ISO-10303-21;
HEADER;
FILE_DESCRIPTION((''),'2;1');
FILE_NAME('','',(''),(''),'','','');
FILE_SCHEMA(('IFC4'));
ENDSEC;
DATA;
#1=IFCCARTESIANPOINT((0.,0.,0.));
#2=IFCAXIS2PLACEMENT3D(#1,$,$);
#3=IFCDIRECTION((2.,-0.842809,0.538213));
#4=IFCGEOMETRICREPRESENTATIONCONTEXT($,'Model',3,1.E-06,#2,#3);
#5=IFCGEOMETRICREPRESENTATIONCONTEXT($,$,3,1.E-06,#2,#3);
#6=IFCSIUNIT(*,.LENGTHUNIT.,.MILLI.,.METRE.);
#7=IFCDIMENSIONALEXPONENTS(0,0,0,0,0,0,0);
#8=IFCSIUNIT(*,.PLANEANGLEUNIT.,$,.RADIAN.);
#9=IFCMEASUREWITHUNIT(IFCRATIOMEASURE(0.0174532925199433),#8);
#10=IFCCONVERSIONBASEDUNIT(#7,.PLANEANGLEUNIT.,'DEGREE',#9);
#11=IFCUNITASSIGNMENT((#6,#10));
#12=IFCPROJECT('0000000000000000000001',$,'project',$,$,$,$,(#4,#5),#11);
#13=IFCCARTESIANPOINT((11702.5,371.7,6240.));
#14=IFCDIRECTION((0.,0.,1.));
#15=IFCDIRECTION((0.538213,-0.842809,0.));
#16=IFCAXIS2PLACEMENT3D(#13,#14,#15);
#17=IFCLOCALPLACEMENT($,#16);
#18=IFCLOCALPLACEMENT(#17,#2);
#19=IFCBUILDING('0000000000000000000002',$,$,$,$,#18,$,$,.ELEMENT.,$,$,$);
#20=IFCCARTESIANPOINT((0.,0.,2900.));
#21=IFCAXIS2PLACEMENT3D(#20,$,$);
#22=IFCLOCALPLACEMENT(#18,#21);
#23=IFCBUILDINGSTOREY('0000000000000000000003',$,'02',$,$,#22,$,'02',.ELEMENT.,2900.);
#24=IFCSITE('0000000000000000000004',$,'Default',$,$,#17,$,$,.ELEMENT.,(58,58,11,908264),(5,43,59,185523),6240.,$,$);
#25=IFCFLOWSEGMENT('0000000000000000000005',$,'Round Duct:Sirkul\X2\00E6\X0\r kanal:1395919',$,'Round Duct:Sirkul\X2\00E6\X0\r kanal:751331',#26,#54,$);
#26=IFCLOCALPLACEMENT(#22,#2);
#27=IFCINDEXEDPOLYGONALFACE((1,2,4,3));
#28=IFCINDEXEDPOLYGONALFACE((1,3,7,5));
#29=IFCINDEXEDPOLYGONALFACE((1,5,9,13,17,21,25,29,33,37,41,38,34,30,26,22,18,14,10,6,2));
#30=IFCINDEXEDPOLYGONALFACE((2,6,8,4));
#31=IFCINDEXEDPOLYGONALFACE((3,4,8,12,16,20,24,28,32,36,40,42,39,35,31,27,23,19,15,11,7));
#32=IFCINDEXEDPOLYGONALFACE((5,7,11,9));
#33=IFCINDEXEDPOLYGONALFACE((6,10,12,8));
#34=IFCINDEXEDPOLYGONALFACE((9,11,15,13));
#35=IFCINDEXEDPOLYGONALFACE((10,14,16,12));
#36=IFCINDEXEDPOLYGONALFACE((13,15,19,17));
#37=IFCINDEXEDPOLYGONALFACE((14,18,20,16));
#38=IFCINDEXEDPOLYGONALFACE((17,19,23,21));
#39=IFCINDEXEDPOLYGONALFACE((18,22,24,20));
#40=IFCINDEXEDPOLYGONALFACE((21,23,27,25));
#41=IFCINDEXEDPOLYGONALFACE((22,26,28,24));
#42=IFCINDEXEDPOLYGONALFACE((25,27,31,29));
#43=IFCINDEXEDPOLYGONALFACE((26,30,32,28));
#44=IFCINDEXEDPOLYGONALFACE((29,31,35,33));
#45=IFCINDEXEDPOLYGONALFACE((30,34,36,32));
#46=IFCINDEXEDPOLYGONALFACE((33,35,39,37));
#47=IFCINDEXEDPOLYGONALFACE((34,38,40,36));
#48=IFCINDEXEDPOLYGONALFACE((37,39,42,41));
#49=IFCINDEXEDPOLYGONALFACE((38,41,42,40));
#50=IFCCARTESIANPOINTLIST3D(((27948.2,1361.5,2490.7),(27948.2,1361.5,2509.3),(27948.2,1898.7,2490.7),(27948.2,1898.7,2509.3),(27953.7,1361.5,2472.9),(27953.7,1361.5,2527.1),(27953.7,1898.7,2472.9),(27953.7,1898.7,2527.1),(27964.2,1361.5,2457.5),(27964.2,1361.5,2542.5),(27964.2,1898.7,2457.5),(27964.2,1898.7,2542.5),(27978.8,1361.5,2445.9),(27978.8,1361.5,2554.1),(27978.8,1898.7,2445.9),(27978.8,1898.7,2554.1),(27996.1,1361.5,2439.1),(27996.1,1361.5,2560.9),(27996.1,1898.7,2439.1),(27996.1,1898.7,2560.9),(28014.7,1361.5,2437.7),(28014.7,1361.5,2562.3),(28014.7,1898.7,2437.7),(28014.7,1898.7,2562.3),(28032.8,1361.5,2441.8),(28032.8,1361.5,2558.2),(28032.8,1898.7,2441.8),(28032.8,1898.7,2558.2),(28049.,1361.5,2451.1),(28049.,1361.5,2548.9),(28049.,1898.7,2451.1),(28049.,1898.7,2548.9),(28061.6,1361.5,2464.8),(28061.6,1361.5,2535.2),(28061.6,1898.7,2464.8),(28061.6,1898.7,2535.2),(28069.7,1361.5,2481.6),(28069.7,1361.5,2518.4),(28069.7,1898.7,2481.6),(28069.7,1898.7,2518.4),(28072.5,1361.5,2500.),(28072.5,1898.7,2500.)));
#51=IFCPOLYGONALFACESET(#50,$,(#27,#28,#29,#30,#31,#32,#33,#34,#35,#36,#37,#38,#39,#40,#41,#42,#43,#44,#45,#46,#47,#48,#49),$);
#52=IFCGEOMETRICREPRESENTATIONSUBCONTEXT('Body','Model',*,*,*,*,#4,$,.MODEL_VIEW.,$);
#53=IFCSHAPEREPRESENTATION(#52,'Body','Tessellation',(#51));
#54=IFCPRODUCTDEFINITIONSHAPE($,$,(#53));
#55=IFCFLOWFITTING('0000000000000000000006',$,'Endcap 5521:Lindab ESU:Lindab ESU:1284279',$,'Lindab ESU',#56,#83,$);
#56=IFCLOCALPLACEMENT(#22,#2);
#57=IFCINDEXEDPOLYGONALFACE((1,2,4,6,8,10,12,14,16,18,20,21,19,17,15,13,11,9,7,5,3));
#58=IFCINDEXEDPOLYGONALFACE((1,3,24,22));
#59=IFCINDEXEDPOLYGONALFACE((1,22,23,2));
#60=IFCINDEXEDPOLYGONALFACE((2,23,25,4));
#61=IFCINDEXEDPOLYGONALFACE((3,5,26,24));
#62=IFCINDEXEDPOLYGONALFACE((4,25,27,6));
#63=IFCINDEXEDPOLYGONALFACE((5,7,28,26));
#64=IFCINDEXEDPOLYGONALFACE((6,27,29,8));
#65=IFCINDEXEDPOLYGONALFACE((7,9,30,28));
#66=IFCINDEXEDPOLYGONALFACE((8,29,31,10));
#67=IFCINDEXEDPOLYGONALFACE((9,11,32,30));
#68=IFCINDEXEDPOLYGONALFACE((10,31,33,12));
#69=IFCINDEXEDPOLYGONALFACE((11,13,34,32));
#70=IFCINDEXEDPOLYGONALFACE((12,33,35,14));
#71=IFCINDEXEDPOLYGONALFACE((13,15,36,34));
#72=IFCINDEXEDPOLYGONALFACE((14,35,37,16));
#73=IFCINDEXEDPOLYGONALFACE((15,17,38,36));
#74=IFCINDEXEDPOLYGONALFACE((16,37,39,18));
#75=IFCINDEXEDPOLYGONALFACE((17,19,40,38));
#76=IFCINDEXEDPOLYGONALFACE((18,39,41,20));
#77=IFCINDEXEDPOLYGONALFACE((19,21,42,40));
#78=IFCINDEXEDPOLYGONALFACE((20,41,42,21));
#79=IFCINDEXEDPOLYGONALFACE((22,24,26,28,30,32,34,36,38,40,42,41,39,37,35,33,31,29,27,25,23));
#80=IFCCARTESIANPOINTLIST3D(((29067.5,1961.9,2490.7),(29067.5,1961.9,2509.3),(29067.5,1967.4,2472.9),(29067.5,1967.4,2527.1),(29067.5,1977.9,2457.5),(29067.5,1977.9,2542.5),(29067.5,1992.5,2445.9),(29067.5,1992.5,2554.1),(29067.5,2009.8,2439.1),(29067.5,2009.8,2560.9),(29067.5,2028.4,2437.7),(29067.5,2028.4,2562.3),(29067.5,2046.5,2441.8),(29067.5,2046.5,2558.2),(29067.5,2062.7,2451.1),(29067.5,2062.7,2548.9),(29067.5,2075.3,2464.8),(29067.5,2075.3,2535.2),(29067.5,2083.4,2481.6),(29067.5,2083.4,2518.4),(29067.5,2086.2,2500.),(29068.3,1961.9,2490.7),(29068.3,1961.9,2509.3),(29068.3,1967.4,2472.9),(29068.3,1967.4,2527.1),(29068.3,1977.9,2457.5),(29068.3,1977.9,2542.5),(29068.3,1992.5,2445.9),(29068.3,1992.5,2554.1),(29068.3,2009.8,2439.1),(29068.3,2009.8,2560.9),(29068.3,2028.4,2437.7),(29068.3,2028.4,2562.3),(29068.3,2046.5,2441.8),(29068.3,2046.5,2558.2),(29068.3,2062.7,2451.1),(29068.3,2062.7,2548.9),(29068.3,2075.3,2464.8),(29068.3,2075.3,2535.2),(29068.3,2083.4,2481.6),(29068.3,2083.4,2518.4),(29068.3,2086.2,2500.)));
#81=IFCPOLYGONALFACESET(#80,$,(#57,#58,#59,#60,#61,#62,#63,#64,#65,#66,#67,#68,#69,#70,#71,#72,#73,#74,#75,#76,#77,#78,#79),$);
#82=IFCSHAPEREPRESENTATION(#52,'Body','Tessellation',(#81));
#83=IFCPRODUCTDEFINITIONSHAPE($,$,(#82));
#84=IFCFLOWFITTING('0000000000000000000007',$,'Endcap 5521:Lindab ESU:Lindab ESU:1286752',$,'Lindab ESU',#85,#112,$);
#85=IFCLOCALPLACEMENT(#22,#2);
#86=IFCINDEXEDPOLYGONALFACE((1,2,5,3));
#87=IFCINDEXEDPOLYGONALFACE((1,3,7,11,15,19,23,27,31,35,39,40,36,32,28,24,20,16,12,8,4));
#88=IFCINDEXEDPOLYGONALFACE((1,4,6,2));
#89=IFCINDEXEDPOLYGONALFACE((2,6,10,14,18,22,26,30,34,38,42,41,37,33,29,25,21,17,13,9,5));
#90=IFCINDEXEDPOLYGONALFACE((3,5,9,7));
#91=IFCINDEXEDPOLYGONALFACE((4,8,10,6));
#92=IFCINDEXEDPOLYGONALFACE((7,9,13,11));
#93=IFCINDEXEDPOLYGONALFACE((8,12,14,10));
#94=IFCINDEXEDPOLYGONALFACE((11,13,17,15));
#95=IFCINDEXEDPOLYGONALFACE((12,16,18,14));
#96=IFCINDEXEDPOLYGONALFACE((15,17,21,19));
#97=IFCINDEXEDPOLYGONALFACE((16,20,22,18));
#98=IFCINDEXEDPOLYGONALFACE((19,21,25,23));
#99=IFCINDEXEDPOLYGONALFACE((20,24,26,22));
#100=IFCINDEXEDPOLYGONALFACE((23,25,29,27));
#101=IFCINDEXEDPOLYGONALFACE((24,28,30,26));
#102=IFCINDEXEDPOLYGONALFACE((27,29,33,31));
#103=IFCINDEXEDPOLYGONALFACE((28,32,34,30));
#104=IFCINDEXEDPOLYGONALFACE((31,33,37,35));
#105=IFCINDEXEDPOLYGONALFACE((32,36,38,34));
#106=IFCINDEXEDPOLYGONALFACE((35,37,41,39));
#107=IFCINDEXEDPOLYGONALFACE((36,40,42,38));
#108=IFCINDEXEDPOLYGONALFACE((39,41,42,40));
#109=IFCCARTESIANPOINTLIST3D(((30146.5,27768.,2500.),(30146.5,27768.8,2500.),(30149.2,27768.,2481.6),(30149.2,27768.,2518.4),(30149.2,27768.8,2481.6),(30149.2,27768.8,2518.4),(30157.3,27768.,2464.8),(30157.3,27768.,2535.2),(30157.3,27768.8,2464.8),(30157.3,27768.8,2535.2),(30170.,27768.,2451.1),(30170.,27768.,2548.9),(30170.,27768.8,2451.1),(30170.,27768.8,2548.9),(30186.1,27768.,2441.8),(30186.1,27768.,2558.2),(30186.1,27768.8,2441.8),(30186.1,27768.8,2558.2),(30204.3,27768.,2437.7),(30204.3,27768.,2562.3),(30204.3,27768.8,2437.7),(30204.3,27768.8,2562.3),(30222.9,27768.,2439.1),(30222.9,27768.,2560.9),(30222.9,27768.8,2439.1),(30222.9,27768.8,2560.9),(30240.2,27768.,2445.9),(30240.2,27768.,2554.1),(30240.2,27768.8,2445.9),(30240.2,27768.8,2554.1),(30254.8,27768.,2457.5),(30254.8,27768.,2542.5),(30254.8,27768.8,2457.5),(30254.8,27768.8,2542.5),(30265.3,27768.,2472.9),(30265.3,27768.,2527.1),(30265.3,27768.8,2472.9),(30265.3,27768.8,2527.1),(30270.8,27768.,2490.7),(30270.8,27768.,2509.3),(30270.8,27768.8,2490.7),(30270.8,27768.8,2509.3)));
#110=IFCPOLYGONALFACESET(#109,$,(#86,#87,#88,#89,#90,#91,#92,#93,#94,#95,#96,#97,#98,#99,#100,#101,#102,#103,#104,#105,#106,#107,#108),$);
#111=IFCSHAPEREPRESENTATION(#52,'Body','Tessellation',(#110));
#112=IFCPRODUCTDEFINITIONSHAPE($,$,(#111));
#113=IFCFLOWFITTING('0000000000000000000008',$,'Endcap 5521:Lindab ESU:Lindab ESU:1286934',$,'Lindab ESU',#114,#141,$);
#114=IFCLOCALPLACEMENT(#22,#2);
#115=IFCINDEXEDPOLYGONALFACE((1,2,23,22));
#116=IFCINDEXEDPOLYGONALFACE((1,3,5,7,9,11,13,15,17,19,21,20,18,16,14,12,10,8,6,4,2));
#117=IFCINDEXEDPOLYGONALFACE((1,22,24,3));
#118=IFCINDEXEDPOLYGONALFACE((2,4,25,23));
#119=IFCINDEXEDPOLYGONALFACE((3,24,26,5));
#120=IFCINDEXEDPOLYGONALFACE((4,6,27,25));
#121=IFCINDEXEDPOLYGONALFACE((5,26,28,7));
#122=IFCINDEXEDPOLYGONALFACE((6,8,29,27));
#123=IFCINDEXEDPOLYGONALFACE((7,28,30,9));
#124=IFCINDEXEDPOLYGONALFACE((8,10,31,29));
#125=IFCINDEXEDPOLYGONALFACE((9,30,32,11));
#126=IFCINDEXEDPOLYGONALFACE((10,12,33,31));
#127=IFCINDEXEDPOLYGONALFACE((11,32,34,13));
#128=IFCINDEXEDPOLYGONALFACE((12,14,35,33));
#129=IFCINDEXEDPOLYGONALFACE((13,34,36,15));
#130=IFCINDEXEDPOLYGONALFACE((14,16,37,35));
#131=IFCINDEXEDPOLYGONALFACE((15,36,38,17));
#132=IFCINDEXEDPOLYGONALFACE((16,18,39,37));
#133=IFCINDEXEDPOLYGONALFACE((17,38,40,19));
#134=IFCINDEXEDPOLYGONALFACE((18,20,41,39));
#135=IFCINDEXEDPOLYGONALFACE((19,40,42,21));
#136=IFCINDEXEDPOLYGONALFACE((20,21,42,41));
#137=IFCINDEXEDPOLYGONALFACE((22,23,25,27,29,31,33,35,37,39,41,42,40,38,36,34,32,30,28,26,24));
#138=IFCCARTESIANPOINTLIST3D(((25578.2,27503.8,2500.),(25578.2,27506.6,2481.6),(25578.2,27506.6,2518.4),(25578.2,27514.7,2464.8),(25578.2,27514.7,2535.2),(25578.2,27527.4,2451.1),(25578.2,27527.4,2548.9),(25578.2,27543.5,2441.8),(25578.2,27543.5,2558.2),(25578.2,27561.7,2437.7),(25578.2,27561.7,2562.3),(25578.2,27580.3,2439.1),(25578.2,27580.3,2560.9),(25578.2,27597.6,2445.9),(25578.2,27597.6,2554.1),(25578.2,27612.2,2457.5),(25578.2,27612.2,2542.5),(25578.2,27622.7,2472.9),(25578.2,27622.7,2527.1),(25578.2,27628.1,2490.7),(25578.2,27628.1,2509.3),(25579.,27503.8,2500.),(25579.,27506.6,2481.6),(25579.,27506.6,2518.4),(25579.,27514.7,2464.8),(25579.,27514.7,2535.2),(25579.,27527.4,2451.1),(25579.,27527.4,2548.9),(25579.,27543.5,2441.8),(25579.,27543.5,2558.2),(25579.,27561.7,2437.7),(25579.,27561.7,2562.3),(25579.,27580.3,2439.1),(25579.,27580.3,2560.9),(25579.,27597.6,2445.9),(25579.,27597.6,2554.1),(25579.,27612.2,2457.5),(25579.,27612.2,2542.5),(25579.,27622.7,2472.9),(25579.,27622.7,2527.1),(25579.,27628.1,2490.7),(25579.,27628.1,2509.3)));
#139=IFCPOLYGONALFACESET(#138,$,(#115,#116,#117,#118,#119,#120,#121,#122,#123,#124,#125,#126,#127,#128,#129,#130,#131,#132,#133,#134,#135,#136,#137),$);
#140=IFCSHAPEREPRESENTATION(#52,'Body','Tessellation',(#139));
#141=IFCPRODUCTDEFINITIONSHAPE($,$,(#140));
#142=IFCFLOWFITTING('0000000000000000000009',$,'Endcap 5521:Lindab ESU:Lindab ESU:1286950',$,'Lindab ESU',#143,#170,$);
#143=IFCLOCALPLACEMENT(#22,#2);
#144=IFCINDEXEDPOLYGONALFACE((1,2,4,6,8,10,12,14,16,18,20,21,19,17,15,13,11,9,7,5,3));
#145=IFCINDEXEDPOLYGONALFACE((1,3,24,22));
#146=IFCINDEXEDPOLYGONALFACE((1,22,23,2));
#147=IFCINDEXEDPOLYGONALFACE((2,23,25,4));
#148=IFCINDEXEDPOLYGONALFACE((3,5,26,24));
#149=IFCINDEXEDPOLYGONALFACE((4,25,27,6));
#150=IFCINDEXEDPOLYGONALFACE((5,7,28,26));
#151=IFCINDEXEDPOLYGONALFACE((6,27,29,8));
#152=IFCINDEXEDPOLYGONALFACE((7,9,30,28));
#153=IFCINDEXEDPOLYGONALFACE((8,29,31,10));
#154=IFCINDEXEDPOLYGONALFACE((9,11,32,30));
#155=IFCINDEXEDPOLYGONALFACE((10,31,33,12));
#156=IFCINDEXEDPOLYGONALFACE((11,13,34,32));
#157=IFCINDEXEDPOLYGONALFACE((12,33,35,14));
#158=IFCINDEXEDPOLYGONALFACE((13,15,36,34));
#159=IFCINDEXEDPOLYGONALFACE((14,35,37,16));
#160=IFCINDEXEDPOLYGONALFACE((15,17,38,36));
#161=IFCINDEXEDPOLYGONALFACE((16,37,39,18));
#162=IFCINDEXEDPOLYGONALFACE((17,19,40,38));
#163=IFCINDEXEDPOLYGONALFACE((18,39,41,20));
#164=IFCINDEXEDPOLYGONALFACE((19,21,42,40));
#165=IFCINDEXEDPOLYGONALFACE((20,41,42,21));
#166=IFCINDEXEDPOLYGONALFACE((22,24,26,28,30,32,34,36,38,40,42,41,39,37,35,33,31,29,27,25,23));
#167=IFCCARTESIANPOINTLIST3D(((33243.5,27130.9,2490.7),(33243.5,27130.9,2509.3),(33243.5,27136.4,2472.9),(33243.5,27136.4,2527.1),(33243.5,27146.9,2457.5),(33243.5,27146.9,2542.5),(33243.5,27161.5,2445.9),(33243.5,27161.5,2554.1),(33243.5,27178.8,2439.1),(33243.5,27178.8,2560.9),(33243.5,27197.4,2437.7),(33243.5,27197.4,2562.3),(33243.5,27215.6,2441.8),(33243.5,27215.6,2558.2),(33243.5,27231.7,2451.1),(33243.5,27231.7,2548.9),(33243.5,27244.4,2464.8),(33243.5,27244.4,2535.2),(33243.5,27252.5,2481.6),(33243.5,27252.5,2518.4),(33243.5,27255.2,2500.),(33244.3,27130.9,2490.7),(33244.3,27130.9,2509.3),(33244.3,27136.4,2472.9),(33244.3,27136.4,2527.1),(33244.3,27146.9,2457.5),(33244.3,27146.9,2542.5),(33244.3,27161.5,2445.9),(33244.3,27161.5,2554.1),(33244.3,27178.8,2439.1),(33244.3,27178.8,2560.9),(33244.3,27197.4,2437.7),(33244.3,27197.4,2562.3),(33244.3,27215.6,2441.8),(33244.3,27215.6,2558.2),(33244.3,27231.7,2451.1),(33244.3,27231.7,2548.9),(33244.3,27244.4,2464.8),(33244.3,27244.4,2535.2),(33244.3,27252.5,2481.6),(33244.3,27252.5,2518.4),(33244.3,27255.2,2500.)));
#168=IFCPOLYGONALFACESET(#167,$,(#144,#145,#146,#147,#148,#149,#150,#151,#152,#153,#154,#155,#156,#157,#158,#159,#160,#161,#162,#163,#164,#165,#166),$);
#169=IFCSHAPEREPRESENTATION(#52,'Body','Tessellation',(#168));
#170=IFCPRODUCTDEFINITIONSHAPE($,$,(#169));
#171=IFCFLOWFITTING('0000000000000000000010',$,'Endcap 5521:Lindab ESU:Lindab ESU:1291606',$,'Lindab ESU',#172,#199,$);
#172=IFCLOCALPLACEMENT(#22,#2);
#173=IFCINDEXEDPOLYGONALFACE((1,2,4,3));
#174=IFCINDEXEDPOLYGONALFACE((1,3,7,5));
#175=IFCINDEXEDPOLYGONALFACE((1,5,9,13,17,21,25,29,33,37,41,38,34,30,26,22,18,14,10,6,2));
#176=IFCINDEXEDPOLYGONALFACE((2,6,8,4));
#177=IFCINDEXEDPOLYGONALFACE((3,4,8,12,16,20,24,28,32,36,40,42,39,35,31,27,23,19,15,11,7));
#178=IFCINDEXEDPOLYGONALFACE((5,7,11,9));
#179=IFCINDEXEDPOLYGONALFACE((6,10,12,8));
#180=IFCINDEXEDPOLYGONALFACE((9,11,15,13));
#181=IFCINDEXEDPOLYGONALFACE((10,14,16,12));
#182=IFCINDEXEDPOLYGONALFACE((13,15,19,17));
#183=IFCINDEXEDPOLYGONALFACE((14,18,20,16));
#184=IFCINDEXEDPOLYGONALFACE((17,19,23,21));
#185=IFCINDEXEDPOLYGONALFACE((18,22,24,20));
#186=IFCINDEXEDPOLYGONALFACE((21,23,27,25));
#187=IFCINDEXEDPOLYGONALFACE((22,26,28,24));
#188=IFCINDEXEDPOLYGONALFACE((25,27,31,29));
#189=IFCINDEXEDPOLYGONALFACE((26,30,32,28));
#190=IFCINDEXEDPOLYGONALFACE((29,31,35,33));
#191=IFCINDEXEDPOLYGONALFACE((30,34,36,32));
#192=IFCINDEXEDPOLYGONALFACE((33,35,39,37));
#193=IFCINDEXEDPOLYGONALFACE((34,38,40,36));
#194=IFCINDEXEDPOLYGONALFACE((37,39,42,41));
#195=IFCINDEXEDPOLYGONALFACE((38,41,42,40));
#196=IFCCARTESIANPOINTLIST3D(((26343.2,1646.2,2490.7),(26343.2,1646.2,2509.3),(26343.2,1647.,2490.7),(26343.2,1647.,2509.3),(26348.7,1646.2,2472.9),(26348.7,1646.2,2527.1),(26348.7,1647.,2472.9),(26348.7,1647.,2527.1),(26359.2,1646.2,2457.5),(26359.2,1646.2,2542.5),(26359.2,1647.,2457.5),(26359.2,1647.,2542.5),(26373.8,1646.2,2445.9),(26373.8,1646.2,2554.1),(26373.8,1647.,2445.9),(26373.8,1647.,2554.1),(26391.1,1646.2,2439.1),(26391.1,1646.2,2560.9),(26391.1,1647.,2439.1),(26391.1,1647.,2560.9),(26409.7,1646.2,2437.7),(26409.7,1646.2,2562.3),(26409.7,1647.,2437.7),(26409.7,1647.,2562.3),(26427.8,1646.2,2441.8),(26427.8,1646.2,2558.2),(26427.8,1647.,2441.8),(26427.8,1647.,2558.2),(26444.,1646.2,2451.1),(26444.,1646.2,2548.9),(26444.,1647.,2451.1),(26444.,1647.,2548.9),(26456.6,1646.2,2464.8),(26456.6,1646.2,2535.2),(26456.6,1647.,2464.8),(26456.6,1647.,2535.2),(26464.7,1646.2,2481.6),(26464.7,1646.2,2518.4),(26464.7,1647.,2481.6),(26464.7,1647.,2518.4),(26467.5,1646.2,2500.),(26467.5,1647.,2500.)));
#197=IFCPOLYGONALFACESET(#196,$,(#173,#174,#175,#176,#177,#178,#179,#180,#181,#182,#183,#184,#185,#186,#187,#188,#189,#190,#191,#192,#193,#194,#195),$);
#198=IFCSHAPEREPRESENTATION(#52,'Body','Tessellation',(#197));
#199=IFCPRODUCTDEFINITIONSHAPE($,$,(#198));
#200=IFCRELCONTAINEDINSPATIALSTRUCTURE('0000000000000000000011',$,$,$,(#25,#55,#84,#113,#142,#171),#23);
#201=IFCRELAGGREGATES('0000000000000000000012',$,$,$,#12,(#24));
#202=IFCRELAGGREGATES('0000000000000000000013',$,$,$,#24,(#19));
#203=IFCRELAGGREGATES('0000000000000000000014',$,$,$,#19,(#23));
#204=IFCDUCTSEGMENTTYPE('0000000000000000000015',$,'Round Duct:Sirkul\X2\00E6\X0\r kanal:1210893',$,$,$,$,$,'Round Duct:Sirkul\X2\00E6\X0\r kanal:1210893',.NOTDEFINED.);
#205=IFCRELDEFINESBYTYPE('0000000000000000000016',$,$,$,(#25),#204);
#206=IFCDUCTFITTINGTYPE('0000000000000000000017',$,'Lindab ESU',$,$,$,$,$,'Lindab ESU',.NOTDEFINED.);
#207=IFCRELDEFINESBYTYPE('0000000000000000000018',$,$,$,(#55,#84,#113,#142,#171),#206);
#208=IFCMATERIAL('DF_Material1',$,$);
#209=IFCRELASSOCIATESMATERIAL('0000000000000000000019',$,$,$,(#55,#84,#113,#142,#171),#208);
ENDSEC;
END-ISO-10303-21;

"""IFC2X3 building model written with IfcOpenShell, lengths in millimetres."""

from ifc_helpers import new_model, entity, si_unit, converted_unit, direction, frame, frame_2d, origin, origin_2d_with_axis, place, context, subcontext, project, spatial, circle, extrude, source, transform, mapped, material, type_object, type_shapes, element, save


model = new_model("IFC2X3")

# Units and contexts
model_context = context("Model", 3, precision=1e-06, world=origin(), true_north=direction((2.0, -0.842809, 0.538213)))
context_of_model = context(None, 3, precision=1e-06, world=origin(), true_north=direction((2.0, -0.842809, 0.538213)))
body_context = subcontext(model_context, "Body", "Model", "MODEL_VIEW")
ifc_project = project(units=[si_unit("LENGTHUNIT", "METRE", prefix="MILLI"), converted_unit("PLANEANGLEUNIT", "DEGREE", entity("IfcRatioMeasure", 0.0174532925199433), si_unit("PLANEANGLEUNIT", "RADIAN"), dimensions=[0, 0, 0, 0, 0, 0, 0])], contexts=[model_context, context_of_model])

# Site, building, storey
site_placement = place(None, frame((11702.5, 371.7, 6240.0), z_axis=(0.0, 0.0, 1.0), x_axis=(0.538213, -0.842809, 0.0)))
site = spatial("IfcSite", under=ifc_project, at=site_placement, Name="Default", CompositionType="ELEMENT", RefLatitude=(58, 58, 11, 908264), RefLongitude=(5, 43, 59, 185523), RefElevation=6240.0)
building_placement = place(site_placement, origin())
building = spatial("IfcBuilding", under=site, at=building_placement, CompositionType="ELEMENT")
storey_placement = place(building_placement, frame((0.0, 0.0, 2900.0)))
storey = spatial("IfcBuildingStorey", under=building, at=storey_placement, Name="02", LongName="02", CompositionType="ELEMENT", Elevation=2900.0)

# Flow segment
duct_segment_type = type_object("IfcDuctSegmentType", Name="Round Duct:Sirkulær kanal:1210893", ElementType="Round Duct:Sirkulær kanal:1210893", PredefinedType="NOTDEFINED")
flow_segment_1_placement = place(storey_placement, origin())
element("IfcFlowSegment", 1, at=flow_segment_1_placement, inside=storey, type_object=duct_segment_type, Name="Round Duct:Sirkulær kanal:1395919", ObjectType="Round Duct:Sirkulær kanal:751331", context=body_context, shape_type="SweptSolid", body=[
    extrude(circle(Radius=62.5, at=origin_2d_with_axis()), frame((28010.0, 1361.5, 2500.0), z_axis=(0.0, 1.0, 0.0), x_axis=(1.0, 0.0, 0.0)), (0.0, 0.0, 1.0), 537.2),
])

# Flow fittings
ifc_material = material(Name="DF_Material1")
duct_fitting_type_1 = type_object("IfcDuctFittingType", Name="Lindab ESU", ElementType="Lindab ESU", PredefinedType="NOTDEFINED")
shared_shape_1 = source(origin(), body_context, "Body", "SweptSolid", [
    extrude(circle(Radius=62.5, at=frame_2d((0.0, 0.0), x_axis=(1.0, 0.0))), frame((0.0, 0.0, 0.0), z_axis=(1.0, 0.0, 0.0), x_axis=(0.0, 1.0, 0.0)), (0.0, 0.0, 1.0), 0.8),
])
type_shapes(duct_fitting_type_1, [shared_shape_1])
flow_fitting_1_placement = place(storey_placement, frame((29067.5, 2023.7, 2500.0)))
element("IfcFlowFitting", 2, at=flow_fitting_1_placement, inside=storey, type_object=duct_fitting_type_1, material=ifc_material, Name="Endcap 5521:Lindab ESU:Lindab ESU:1284279", ObjectType="Lindab ESU", context=body_context, shape_type="MappedRepresentation", body=[
    mapped(shared_shape_1, transform((0.0, 0.0, 0.0), scale=1.0)),
])
for number, where, z_axis, x_axis, name in (
    (3, (30209.0, 27768.0, 2500.0), (0.0, 0.0, 1.0), (0.0, 1.0, 0.0), "Endcap 5521:Lindab ESU:Lindab ESU:1286752"),
    (4, (25579.0, 27566.3, 2500.0), (0.0, 0.0, 1.0), (-1.0, 0.0, 0.0), "Endcap 5521:Lindab ESU:Lindab ESU:1286934"),
):
    element("IfcFlowFitting", number, at=place(storey_placement, frame(where, z_axis=z_axis, x_axis=x_axis)), inside=storey, type_object=duct_fitting_type_1, material=ifc_material, Name=name, ObjectType="Lindab ESU", context=body_context, shape_type="MappedRepresentation", body=[
        mapped(shared_shape_1, transform((0.0, 0.0, 0.0), scale=1.0)),
    ])
flow_fitting_2_placement = place(storey_placement, frame((33243.5, 27192.7, 2500.0)))
element("IfcFlowFitting", 5, at=flow_fitting_2_placement, inside=storey, type_object=duct_fitting_type_1, material=ifc_material, Name="Endcap 5521:Lindab ESU:Lindab ESU:1286950", ObjectType="Lindab ESU", context=body_context, shape_type="MappedRepresentation", body=[
    mapped(shared_shape_1, transform((0.0, 0.0, 0.0), scale=1.0)),
])
flow_fitting_3_placement = place(storey_placement, frame((26405.0, 1647.0, 2500.0), z_axis=(0.0, 0.0, 1.0), x_axis=(0.0, -1.0, 0.0)))
element("IfcFlowFitting", 6, at=flow_fitting_3_placement, inside=storey, type_object=duct_fitting_type_1, material=ifc_material, Name="Endcap 5521:Lindab ESU:Lindab ESU:1291606", ObjectType="Lindab ESU", context=body_context, shape_type="MappedRepresentation", body=[
    mapped(shared_shape_1, transform((0.0, 0.0, 0.0), scale=1.0)),
])

save(model, "model.ifc")
